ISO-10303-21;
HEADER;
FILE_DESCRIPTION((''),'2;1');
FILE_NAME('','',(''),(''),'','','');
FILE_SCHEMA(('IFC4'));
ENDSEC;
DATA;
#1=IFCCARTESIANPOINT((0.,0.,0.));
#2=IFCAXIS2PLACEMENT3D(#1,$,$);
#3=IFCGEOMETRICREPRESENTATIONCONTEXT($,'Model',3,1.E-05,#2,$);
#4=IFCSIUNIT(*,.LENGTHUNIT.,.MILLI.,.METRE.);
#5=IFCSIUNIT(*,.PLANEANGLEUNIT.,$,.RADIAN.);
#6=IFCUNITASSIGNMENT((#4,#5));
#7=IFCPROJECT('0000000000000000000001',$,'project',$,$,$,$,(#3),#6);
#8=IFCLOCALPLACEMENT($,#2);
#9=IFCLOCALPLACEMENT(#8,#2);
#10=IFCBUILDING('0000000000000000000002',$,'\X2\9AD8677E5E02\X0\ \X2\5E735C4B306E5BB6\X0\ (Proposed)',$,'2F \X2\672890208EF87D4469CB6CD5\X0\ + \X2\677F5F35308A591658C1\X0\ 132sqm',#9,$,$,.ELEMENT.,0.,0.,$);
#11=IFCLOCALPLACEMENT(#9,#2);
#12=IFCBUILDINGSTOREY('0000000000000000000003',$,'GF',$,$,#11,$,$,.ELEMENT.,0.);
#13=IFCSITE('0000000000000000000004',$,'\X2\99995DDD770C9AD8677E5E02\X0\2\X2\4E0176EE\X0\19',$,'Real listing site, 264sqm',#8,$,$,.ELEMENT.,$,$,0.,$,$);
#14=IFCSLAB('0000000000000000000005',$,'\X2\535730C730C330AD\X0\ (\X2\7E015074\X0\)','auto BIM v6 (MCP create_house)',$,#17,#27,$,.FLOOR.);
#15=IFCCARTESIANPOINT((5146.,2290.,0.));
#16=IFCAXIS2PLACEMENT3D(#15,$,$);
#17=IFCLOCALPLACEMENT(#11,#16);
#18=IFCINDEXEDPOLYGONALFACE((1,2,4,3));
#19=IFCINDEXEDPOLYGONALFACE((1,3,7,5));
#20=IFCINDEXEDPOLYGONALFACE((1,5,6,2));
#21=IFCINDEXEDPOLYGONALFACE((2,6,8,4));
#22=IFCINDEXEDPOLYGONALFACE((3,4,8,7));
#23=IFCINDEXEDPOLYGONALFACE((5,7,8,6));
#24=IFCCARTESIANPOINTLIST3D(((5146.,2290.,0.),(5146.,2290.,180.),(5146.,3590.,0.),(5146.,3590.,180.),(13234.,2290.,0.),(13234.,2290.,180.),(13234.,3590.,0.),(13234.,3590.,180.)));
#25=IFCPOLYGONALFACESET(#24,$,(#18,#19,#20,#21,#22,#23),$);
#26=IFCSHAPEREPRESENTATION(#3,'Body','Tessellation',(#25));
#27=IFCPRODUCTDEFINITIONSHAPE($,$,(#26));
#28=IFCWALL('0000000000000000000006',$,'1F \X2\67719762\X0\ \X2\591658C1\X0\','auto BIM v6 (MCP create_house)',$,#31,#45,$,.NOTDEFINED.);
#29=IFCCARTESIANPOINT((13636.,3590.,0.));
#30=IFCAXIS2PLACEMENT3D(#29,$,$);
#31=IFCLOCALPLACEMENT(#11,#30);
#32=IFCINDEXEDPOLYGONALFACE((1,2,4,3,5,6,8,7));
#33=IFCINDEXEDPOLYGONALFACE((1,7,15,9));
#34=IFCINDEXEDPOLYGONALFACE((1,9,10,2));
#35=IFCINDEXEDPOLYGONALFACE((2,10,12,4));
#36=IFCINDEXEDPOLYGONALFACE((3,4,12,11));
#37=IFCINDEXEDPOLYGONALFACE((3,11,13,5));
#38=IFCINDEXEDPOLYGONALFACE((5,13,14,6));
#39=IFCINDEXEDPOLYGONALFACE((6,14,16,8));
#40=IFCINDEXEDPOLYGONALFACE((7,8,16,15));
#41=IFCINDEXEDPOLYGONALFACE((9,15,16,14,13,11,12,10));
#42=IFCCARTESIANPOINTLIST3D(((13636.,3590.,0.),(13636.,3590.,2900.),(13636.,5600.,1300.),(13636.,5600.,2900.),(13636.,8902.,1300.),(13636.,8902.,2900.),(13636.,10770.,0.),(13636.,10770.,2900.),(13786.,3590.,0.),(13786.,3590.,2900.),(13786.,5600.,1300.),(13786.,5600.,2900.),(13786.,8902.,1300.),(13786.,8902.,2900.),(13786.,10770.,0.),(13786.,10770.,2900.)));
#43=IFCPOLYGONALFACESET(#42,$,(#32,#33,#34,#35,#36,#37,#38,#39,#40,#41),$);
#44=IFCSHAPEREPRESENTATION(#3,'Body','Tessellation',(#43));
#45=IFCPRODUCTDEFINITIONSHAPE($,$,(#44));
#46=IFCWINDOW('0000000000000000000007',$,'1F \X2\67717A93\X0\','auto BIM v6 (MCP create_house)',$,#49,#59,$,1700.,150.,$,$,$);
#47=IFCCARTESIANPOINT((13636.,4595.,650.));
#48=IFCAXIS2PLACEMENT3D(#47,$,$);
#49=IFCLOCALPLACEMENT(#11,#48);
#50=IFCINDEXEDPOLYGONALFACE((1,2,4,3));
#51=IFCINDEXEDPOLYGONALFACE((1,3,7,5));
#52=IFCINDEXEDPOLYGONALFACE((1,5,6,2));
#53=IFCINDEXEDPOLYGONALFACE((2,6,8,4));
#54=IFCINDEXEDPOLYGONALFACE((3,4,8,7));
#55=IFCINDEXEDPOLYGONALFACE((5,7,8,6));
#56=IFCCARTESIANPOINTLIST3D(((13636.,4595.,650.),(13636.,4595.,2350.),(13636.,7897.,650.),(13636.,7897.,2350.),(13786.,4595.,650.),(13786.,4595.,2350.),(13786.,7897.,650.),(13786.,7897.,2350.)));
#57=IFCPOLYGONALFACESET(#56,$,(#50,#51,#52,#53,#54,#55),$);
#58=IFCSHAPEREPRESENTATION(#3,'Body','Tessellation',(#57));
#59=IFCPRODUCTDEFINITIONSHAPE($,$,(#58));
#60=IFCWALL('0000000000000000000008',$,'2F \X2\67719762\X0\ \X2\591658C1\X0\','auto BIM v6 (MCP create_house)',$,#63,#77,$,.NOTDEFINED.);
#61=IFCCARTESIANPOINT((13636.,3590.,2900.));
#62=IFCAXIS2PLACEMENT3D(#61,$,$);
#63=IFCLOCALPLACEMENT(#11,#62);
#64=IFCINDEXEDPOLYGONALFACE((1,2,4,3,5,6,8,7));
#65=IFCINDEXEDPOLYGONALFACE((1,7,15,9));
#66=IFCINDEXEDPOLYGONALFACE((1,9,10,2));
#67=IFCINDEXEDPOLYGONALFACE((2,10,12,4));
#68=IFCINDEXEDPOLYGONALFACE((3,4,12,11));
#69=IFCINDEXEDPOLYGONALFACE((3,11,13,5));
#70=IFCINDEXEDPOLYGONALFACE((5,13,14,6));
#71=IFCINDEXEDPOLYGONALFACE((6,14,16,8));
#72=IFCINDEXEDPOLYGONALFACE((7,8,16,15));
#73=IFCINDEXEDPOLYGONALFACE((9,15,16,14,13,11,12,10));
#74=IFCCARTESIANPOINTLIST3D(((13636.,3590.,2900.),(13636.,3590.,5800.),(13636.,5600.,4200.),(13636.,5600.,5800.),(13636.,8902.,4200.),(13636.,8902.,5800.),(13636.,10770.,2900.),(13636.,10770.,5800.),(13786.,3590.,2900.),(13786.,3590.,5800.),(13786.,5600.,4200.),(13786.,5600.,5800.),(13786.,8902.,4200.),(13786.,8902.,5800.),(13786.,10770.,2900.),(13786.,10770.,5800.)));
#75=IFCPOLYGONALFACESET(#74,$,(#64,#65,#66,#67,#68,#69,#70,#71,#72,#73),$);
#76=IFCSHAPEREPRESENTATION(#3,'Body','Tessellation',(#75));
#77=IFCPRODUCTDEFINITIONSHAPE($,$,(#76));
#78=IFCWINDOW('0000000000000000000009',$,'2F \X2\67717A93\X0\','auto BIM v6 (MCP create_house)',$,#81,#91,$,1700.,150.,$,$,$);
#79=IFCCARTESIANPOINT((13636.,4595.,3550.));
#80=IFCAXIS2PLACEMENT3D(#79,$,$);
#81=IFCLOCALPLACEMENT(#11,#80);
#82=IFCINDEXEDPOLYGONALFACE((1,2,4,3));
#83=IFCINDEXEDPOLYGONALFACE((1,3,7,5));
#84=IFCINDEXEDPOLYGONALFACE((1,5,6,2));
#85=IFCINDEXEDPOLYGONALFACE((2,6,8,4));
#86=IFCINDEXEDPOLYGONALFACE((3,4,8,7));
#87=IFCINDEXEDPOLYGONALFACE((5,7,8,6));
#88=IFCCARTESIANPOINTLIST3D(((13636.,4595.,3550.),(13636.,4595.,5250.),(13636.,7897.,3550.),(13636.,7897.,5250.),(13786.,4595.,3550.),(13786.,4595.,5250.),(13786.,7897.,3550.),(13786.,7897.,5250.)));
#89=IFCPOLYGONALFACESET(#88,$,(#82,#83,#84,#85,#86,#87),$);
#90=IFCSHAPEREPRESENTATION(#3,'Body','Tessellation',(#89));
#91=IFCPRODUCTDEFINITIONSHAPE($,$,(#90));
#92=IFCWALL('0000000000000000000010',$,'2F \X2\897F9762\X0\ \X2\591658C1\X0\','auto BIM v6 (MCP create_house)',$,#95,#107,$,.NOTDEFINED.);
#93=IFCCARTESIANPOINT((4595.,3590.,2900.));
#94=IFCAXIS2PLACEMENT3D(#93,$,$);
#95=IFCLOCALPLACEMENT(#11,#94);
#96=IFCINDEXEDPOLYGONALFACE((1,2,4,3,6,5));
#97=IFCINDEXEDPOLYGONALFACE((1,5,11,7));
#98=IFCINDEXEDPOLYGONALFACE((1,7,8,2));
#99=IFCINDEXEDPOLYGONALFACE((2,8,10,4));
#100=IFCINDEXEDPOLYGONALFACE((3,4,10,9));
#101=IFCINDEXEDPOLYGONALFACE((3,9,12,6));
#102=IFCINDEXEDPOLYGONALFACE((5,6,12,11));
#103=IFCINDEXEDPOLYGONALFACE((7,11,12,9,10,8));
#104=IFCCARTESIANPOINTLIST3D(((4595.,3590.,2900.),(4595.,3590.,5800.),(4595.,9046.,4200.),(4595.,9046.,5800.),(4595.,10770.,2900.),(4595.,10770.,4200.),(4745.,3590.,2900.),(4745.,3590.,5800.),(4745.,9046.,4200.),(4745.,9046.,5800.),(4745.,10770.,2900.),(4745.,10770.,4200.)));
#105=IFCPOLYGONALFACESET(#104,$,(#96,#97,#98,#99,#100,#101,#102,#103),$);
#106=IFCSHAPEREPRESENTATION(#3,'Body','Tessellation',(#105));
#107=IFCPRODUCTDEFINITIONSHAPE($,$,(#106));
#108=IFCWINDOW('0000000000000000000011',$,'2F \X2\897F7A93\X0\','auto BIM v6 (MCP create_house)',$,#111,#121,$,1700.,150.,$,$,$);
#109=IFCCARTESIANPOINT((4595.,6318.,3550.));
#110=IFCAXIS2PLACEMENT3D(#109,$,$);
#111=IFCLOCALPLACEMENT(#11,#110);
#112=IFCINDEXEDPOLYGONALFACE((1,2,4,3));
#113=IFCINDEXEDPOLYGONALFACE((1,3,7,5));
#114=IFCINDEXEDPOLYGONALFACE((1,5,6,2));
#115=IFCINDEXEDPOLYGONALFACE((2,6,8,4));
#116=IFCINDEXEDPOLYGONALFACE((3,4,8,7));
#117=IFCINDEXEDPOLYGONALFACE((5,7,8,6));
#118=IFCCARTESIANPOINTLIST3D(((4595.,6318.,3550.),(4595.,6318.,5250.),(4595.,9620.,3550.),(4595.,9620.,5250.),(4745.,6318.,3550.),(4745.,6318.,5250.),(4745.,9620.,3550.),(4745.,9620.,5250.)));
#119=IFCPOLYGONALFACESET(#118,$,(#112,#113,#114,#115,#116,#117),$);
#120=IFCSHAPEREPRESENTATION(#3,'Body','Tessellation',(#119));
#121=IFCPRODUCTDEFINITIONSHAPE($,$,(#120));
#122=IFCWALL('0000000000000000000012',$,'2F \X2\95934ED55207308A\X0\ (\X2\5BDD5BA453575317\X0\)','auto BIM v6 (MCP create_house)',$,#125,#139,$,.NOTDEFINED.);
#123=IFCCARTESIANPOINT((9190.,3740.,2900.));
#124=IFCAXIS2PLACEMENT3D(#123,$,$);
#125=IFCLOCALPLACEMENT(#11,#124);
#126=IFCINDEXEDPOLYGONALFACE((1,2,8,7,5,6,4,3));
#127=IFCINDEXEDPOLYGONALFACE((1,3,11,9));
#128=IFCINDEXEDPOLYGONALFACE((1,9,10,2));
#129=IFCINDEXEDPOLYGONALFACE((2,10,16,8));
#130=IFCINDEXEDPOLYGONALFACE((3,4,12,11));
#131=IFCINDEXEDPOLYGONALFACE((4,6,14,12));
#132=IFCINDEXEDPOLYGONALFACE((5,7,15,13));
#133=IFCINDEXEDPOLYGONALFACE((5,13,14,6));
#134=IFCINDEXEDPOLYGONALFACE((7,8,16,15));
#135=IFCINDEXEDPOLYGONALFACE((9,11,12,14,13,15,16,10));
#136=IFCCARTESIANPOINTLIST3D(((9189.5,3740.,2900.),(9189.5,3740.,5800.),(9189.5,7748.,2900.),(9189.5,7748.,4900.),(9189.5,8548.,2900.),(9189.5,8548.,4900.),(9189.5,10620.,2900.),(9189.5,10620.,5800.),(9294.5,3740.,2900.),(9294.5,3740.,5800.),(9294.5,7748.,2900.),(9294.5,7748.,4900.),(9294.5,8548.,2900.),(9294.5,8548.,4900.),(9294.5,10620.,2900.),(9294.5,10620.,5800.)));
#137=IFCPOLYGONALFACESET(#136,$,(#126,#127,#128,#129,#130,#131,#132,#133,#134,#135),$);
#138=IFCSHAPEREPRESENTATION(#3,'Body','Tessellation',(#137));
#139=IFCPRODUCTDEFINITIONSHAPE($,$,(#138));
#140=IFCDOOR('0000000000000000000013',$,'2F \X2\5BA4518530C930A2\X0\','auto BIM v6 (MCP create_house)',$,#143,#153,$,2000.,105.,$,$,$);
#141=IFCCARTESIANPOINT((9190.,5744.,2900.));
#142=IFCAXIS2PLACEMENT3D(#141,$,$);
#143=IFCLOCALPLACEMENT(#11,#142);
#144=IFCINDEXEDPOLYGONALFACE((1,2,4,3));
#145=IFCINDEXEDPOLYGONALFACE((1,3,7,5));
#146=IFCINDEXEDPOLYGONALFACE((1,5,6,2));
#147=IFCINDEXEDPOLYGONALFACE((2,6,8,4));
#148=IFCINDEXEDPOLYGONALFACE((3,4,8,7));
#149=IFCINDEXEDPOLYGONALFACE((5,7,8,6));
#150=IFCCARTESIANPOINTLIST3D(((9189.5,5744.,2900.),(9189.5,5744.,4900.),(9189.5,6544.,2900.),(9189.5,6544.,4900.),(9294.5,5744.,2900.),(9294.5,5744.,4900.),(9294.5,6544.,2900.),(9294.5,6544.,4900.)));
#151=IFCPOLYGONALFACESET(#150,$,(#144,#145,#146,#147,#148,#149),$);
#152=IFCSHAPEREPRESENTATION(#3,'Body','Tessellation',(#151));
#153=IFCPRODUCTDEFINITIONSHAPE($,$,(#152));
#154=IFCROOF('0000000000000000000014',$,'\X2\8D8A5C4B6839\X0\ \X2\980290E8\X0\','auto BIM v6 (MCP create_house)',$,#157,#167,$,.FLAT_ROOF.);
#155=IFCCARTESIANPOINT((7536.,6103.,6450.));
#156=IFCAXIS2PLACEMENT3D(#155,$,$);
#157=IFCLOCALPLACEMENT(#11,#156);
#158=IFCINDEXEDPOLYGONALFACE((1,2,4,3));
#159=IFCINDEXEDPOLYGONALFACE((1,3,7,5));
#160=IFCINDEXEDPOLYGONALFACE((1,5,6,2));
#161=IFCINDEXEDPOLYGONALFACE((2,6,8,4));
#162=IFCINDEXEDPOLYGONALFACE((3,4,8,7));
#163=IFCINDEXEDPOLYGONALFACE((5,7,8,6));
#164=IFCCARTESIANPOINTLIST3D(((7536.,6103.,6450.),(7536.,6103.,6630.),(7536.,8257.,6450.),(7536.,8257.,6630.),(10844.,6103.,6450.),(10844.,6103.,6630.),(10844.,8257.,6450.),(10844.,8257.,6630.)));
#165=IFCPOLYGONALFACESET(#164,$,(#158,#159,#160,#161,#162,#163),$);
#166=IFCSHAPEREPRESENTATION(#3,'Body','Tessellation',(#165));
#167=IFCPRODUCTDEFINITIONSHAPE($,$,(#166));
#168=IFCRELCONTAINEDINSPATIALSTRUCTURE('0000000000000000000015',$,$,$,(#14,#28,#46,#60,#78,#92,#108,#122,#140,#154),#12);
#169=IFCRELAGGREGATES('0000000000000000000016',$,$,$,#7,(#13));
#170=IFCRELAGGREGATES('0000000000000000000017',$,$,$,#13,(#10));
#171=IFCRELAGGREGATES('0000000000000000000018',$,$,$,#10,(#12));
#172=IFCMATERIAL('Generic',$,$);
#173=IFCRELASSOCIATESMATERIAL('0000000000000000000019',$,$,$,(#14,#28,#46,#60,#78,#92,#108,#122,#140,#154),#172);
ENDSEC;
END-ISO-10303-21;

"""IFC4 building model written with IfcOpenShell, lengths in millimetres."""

from ifc_helpers import new_model, si_unit, frame, frame_2d, origin, place, context, project, spatial, rectangle, extrude, material, element, fill, save


model = new_model("IFC4")

# Units and contexts
model_context = context("Model", 3, precision=1e-05, world=origin())
ifc_project = project(units=[si_unit("LENGTHUNIT", "METRE", prefix="MILLI"), si_unit("PLANEANGLEUNIT", "RADIAN")], contexts=[model_context])

# Site, building, storey
site_placement = place(None, origin())
site = spatial("IfcSite", under=ifc_project, at=site_placement, Name="香川県高松市2丁目19", ObjectType="Real listing site, 264sqm", CompositionType="ELEMENT", RefElevation=0.0)
building_placement = place(site_placement, origin())
building = spatial("IfcBuilding", under=site, at=building_placement, Name="高松市 平屋の家 (Proposed)", ObjectType="2F 木造軸組構法 + 板張り外壁 132sqm", CompositionType="ELEMENT", ElevationOfRefHeight=0.0, ElevationOfTerrain=0.0)
storey_placement = place(building_placement, origin())
storey = spatial("IfcBuildingStorey", under=building, at=storey_placement, Name="GF", CompositionType="ELEMENT", Elevation=0.0)

# Slab
ifc_material = material(Name="Generic")
slab_placement = place(storey_placement, frame((5146.0, 2290.0, 0.0)))
element("IfcSlab", 1, at=slab_placement, inside=storey, material=ifc_material, Name="南デッキ (縁側)", Description="auto BIM v6 (MCP create_house)", PredefinedType="FLOOR", context=model_context, shape_type="SweptSolid", body=[
    extrude(rectangle(XDim=8088.0, YDim=1300.0, at=frame_2d((4044.0, 650.0))), frame((5146.0, 2290.0, 0.0)), (0.0, 0.0, 1.0), 180.0),
])

# Wall, opening, window
wall_1_placement = place(storey_placement, frame((13636.0, 3590.0, 0.0)))
wall_1 = element("IfcWall", 2, at=wall_1_placement, inside=storey, material=ifc_material, Name="1F 東面 外壁", Description="auto BIM v6 (MCP create_house)", PredefinedType="NOTDEFINED", context=model_context, shape_type="SweptSolid", body=[
    extrude(rectangle(XDim=150.0, YDim=7180.0, at=frame_2d((75.0, 3590.0))), frame((13636.0, 3590.0, 0.0)), (0.0, 0.0, 1.0), 2900.0),
])
opening_1_placement = place(storey_placement, frame((13636.0, 4595.0, 650.0)))
opening_1 = element("IfcOpeningElement", 3, at=opening_1_placement, cuts=wall_1, PredefinedType="NOTDEFINED", context=model_context, shape_type="SweptSolid", body=[
    extrude(rectangle(XDim=150.0, YDim=3302.0, at=frame_2d((75.0, 1651.0))), frame((13636.0, 4595.0, 650.0)), (0.0, 0.0, 1.0), 1700.0),
])
window_1_placement = place(storey_placement, frame((13636.0, 4595.0, 650.0)))
window_1 = element("IfcWindow", 4, at=window_1_placement, inside=storey, material=ifc_material, Name="1F 東窓", Description="auto BIM v6 (MCP create_house)", OverallHeight=1700.0, OverallWidth=150.0, context=model_context, shape_type="SweptSolid", body=[
    extrude(rectangle(XDim=150.0, YDim=3302.0, at=frame_2d((75.0, 1651.0))), frame((13636.0, 4595.0, 650.0)), (0.0, 0.0, 1.0), 1700.0),
])
fill(opening_1, window_1)

# Walls, openings, windows
wall_2_placement = place(storey_placement, frame((13636.0, 3590.0, 2900.0)))
wall_2 = element("IfcWall", 5, at=wall_2_placement, inside=storey, material=ifc_material, Name="2F 東面 外壁", Description="auto BIM v6 (MCP create_house)", PredefinedType="NOTDEFINED", context=model_context, shape_type="SweptSolid", body=[
    extrude(rectangle(XDim=150.0, YDim=7180.0, at=frame_2d((75.0, 3590.0))), frame((13636.0, 3590.0, 2900.0)), (0.0, 0.0, 1.0), 2900.0),
])
opening_2_placement = place(storey_placement, frame((13636.0, 4595.0, 3550.0)))
opening_2 = element("IfcOpeningElement", 6, at=opening_2_placement, cuts=wall_2, PredefinedType="NOTDEFINED", context=model_context, shape_type="SweptSolid", body=[
    extrude(rectangle(XDim=150.0, YDim=3302.0, at=frame_2d((75.0, 1651.0))), frame((13636.0, 4595.0, 3550.0)), (0.0, 0.0, 1.0), 1700.0),
])
window_2_placement = place(storey_placement, frame((13636.0, 4595.0, 3550.0)))
window_2 = element("IfcWindow", 7, at=window_2_placement, inside=storey, material=ifc_material, Name="2F 東窓", Description="auto BIM v6 (MCP create_house)", OverallHeight=1700.0, OverallWidth=150.0, context=model_context, shape_type="SweptSolid", body=[
    extrude(rectangle(XDim=150.0, YDim=3302.0, at=frame_2d((75.0, 1651.0))), frame((13636.0, 4595.0, 3550.0)), (0.0, 0.0, 1.0), 1700.0),
])
fill(opening_2, window_2)
wall_3_placement = place(storey_placement, frame((4595.0, 3590.0, 2900.0)))
wall_3 = element("IfcWall", 8, at=wall_3_placement, inside=storey, material=ifc_material, Name="2F 西面 外壁", Description="auto BIM v6 (MCP create_house)", PredefinedType="NOTDEFINED", context=model_context, shape_type="SweptSolid", body=[
    extrude(rectangle(XDim=150.0, YDim=7180.0, at=frame_2d((75.0, 3590.0))), frame((4595.0, 3590.0, 2900.0)), (0.0, 0.0, 1.0), 2900.0),
])
opening_3_placement = place(storey_placement, frame((4595.0, 6318.0, 3550.0)))
opening_3 = element("IfcOpeningElement", 9, at=opening_3_placement, cuts=wall_3, PredefinedType="NOTDEFINED", context=model_context, shape_type="SweptSolid", body=[
    extrude(rectangle(XDim=150.0, YDim=3302.0, at=frame_2d((75.0, 1651.0))), frame((4595.0, 6318.0, 3550.0)), (0.0, 0.0, 1.0), 1700.0),
])
window_3_placement = place(storey_placement, frame((4595.0, 6318.0, 3550.0)))
window_3 = element("IfcWindow", 10, at=window_3_placement, inside=storey, material=ifc_material, Name="2F 西窓", Description="auto BIM v6 (MCP create_house)", OverallHeight=1700.0, OverallWidth=150.0, context=model_context, shape_type="SweptSolid", body=[
    extrude(rectangle(XDim=150.0, YDim=3302.0, at=frame_2d((75.0, 1651.0))), frame((4595.0, 6318.0, 3550.0)), (0.0, 0.0, 1.0), 1700.0),
])
fill(opening_3, window_3)

# Wall, opening, door
wall_4_placement = place(storey_placement, frame((9190.0, 3740.0, 2900.0)))
wall_4 = element("IfcWall", 11, at=wall_4_placement, inside=storey, material=ifc_material, Name="2F 間仕切り (寝室南北)", Description="auto BIM v6 (MCP create_house)", PredefinedType="NOTDEFINED", context=model_context, shape_type="SweptSolid", body=[
    extrude(rectangle(XDim=105.0, YDim=6880.0, at=frame_2d((52.0, 3440.0))), frame((9190.0, 3740.0, 2900.0)), (0.0, 0.0, 1.0), 2900.0),
])
opening_4_placement = place(storey_placement, frame((9190.0, 5744.0, 2900.0)))
opening_4 = element("IfcOpeningElement", 12, at=opening_4_placement, cuts=wall_4, PredefinedType="NOTDEFINED", context=model_context, shape_type="SweptSolid", body=[
    extrude(rectangle(XDim=105.0, YDim=800.0, at=frame_2d((52.0, 400.0))), frame((9190.0, 5744.0, 2900.0)), (0.0, 0.0, 1.0), 2000.0),
])
door_placement = place(storey_placement, frame((9190.0, 5744.0, 2900.0)))
door = element("IfcDoor", 13, at=door_placement, inside=storey, material=ifc_material, Name="2F 室内ドア", Description="auto BIM v6 (MCP create_house)", OverallHeight=2000.0, OverallWidth=105.0, context=model_context, shape_type="SweptSolid", body=[
    extrude(rectangle(XDim=105.0, YDim=800.0, at=frame_2d((52.0, 400.0))), frame((9190.0, 5744.0, 2900.0)), (0.0, 0.0, 1.0), 2000.0),
])
fill(opening_4, door)

# Roof
roof_placement = place(storey_placement, frame((7536.0, 6103.0, 6450.0)))
element("IfcRoof", 14, at=roof_placement, inside=storey, material=ifc_material, Name="越屋根 頂部", Description="auto BIM v6 (MCP create_house)", PredefinedType="FLAT_ROOF", context=model_context, shape_type="SweptSolid", body=[
    extrude(rectangle(XDim=3308.0, YDim=2154.0, at=frame_2d((1654.0, 1077.0))), frame((7536.0, 6103.0, 6450.0)), (0.0, 0.0, 1.0), 180.0),
])

save(model, "model.ifc")
